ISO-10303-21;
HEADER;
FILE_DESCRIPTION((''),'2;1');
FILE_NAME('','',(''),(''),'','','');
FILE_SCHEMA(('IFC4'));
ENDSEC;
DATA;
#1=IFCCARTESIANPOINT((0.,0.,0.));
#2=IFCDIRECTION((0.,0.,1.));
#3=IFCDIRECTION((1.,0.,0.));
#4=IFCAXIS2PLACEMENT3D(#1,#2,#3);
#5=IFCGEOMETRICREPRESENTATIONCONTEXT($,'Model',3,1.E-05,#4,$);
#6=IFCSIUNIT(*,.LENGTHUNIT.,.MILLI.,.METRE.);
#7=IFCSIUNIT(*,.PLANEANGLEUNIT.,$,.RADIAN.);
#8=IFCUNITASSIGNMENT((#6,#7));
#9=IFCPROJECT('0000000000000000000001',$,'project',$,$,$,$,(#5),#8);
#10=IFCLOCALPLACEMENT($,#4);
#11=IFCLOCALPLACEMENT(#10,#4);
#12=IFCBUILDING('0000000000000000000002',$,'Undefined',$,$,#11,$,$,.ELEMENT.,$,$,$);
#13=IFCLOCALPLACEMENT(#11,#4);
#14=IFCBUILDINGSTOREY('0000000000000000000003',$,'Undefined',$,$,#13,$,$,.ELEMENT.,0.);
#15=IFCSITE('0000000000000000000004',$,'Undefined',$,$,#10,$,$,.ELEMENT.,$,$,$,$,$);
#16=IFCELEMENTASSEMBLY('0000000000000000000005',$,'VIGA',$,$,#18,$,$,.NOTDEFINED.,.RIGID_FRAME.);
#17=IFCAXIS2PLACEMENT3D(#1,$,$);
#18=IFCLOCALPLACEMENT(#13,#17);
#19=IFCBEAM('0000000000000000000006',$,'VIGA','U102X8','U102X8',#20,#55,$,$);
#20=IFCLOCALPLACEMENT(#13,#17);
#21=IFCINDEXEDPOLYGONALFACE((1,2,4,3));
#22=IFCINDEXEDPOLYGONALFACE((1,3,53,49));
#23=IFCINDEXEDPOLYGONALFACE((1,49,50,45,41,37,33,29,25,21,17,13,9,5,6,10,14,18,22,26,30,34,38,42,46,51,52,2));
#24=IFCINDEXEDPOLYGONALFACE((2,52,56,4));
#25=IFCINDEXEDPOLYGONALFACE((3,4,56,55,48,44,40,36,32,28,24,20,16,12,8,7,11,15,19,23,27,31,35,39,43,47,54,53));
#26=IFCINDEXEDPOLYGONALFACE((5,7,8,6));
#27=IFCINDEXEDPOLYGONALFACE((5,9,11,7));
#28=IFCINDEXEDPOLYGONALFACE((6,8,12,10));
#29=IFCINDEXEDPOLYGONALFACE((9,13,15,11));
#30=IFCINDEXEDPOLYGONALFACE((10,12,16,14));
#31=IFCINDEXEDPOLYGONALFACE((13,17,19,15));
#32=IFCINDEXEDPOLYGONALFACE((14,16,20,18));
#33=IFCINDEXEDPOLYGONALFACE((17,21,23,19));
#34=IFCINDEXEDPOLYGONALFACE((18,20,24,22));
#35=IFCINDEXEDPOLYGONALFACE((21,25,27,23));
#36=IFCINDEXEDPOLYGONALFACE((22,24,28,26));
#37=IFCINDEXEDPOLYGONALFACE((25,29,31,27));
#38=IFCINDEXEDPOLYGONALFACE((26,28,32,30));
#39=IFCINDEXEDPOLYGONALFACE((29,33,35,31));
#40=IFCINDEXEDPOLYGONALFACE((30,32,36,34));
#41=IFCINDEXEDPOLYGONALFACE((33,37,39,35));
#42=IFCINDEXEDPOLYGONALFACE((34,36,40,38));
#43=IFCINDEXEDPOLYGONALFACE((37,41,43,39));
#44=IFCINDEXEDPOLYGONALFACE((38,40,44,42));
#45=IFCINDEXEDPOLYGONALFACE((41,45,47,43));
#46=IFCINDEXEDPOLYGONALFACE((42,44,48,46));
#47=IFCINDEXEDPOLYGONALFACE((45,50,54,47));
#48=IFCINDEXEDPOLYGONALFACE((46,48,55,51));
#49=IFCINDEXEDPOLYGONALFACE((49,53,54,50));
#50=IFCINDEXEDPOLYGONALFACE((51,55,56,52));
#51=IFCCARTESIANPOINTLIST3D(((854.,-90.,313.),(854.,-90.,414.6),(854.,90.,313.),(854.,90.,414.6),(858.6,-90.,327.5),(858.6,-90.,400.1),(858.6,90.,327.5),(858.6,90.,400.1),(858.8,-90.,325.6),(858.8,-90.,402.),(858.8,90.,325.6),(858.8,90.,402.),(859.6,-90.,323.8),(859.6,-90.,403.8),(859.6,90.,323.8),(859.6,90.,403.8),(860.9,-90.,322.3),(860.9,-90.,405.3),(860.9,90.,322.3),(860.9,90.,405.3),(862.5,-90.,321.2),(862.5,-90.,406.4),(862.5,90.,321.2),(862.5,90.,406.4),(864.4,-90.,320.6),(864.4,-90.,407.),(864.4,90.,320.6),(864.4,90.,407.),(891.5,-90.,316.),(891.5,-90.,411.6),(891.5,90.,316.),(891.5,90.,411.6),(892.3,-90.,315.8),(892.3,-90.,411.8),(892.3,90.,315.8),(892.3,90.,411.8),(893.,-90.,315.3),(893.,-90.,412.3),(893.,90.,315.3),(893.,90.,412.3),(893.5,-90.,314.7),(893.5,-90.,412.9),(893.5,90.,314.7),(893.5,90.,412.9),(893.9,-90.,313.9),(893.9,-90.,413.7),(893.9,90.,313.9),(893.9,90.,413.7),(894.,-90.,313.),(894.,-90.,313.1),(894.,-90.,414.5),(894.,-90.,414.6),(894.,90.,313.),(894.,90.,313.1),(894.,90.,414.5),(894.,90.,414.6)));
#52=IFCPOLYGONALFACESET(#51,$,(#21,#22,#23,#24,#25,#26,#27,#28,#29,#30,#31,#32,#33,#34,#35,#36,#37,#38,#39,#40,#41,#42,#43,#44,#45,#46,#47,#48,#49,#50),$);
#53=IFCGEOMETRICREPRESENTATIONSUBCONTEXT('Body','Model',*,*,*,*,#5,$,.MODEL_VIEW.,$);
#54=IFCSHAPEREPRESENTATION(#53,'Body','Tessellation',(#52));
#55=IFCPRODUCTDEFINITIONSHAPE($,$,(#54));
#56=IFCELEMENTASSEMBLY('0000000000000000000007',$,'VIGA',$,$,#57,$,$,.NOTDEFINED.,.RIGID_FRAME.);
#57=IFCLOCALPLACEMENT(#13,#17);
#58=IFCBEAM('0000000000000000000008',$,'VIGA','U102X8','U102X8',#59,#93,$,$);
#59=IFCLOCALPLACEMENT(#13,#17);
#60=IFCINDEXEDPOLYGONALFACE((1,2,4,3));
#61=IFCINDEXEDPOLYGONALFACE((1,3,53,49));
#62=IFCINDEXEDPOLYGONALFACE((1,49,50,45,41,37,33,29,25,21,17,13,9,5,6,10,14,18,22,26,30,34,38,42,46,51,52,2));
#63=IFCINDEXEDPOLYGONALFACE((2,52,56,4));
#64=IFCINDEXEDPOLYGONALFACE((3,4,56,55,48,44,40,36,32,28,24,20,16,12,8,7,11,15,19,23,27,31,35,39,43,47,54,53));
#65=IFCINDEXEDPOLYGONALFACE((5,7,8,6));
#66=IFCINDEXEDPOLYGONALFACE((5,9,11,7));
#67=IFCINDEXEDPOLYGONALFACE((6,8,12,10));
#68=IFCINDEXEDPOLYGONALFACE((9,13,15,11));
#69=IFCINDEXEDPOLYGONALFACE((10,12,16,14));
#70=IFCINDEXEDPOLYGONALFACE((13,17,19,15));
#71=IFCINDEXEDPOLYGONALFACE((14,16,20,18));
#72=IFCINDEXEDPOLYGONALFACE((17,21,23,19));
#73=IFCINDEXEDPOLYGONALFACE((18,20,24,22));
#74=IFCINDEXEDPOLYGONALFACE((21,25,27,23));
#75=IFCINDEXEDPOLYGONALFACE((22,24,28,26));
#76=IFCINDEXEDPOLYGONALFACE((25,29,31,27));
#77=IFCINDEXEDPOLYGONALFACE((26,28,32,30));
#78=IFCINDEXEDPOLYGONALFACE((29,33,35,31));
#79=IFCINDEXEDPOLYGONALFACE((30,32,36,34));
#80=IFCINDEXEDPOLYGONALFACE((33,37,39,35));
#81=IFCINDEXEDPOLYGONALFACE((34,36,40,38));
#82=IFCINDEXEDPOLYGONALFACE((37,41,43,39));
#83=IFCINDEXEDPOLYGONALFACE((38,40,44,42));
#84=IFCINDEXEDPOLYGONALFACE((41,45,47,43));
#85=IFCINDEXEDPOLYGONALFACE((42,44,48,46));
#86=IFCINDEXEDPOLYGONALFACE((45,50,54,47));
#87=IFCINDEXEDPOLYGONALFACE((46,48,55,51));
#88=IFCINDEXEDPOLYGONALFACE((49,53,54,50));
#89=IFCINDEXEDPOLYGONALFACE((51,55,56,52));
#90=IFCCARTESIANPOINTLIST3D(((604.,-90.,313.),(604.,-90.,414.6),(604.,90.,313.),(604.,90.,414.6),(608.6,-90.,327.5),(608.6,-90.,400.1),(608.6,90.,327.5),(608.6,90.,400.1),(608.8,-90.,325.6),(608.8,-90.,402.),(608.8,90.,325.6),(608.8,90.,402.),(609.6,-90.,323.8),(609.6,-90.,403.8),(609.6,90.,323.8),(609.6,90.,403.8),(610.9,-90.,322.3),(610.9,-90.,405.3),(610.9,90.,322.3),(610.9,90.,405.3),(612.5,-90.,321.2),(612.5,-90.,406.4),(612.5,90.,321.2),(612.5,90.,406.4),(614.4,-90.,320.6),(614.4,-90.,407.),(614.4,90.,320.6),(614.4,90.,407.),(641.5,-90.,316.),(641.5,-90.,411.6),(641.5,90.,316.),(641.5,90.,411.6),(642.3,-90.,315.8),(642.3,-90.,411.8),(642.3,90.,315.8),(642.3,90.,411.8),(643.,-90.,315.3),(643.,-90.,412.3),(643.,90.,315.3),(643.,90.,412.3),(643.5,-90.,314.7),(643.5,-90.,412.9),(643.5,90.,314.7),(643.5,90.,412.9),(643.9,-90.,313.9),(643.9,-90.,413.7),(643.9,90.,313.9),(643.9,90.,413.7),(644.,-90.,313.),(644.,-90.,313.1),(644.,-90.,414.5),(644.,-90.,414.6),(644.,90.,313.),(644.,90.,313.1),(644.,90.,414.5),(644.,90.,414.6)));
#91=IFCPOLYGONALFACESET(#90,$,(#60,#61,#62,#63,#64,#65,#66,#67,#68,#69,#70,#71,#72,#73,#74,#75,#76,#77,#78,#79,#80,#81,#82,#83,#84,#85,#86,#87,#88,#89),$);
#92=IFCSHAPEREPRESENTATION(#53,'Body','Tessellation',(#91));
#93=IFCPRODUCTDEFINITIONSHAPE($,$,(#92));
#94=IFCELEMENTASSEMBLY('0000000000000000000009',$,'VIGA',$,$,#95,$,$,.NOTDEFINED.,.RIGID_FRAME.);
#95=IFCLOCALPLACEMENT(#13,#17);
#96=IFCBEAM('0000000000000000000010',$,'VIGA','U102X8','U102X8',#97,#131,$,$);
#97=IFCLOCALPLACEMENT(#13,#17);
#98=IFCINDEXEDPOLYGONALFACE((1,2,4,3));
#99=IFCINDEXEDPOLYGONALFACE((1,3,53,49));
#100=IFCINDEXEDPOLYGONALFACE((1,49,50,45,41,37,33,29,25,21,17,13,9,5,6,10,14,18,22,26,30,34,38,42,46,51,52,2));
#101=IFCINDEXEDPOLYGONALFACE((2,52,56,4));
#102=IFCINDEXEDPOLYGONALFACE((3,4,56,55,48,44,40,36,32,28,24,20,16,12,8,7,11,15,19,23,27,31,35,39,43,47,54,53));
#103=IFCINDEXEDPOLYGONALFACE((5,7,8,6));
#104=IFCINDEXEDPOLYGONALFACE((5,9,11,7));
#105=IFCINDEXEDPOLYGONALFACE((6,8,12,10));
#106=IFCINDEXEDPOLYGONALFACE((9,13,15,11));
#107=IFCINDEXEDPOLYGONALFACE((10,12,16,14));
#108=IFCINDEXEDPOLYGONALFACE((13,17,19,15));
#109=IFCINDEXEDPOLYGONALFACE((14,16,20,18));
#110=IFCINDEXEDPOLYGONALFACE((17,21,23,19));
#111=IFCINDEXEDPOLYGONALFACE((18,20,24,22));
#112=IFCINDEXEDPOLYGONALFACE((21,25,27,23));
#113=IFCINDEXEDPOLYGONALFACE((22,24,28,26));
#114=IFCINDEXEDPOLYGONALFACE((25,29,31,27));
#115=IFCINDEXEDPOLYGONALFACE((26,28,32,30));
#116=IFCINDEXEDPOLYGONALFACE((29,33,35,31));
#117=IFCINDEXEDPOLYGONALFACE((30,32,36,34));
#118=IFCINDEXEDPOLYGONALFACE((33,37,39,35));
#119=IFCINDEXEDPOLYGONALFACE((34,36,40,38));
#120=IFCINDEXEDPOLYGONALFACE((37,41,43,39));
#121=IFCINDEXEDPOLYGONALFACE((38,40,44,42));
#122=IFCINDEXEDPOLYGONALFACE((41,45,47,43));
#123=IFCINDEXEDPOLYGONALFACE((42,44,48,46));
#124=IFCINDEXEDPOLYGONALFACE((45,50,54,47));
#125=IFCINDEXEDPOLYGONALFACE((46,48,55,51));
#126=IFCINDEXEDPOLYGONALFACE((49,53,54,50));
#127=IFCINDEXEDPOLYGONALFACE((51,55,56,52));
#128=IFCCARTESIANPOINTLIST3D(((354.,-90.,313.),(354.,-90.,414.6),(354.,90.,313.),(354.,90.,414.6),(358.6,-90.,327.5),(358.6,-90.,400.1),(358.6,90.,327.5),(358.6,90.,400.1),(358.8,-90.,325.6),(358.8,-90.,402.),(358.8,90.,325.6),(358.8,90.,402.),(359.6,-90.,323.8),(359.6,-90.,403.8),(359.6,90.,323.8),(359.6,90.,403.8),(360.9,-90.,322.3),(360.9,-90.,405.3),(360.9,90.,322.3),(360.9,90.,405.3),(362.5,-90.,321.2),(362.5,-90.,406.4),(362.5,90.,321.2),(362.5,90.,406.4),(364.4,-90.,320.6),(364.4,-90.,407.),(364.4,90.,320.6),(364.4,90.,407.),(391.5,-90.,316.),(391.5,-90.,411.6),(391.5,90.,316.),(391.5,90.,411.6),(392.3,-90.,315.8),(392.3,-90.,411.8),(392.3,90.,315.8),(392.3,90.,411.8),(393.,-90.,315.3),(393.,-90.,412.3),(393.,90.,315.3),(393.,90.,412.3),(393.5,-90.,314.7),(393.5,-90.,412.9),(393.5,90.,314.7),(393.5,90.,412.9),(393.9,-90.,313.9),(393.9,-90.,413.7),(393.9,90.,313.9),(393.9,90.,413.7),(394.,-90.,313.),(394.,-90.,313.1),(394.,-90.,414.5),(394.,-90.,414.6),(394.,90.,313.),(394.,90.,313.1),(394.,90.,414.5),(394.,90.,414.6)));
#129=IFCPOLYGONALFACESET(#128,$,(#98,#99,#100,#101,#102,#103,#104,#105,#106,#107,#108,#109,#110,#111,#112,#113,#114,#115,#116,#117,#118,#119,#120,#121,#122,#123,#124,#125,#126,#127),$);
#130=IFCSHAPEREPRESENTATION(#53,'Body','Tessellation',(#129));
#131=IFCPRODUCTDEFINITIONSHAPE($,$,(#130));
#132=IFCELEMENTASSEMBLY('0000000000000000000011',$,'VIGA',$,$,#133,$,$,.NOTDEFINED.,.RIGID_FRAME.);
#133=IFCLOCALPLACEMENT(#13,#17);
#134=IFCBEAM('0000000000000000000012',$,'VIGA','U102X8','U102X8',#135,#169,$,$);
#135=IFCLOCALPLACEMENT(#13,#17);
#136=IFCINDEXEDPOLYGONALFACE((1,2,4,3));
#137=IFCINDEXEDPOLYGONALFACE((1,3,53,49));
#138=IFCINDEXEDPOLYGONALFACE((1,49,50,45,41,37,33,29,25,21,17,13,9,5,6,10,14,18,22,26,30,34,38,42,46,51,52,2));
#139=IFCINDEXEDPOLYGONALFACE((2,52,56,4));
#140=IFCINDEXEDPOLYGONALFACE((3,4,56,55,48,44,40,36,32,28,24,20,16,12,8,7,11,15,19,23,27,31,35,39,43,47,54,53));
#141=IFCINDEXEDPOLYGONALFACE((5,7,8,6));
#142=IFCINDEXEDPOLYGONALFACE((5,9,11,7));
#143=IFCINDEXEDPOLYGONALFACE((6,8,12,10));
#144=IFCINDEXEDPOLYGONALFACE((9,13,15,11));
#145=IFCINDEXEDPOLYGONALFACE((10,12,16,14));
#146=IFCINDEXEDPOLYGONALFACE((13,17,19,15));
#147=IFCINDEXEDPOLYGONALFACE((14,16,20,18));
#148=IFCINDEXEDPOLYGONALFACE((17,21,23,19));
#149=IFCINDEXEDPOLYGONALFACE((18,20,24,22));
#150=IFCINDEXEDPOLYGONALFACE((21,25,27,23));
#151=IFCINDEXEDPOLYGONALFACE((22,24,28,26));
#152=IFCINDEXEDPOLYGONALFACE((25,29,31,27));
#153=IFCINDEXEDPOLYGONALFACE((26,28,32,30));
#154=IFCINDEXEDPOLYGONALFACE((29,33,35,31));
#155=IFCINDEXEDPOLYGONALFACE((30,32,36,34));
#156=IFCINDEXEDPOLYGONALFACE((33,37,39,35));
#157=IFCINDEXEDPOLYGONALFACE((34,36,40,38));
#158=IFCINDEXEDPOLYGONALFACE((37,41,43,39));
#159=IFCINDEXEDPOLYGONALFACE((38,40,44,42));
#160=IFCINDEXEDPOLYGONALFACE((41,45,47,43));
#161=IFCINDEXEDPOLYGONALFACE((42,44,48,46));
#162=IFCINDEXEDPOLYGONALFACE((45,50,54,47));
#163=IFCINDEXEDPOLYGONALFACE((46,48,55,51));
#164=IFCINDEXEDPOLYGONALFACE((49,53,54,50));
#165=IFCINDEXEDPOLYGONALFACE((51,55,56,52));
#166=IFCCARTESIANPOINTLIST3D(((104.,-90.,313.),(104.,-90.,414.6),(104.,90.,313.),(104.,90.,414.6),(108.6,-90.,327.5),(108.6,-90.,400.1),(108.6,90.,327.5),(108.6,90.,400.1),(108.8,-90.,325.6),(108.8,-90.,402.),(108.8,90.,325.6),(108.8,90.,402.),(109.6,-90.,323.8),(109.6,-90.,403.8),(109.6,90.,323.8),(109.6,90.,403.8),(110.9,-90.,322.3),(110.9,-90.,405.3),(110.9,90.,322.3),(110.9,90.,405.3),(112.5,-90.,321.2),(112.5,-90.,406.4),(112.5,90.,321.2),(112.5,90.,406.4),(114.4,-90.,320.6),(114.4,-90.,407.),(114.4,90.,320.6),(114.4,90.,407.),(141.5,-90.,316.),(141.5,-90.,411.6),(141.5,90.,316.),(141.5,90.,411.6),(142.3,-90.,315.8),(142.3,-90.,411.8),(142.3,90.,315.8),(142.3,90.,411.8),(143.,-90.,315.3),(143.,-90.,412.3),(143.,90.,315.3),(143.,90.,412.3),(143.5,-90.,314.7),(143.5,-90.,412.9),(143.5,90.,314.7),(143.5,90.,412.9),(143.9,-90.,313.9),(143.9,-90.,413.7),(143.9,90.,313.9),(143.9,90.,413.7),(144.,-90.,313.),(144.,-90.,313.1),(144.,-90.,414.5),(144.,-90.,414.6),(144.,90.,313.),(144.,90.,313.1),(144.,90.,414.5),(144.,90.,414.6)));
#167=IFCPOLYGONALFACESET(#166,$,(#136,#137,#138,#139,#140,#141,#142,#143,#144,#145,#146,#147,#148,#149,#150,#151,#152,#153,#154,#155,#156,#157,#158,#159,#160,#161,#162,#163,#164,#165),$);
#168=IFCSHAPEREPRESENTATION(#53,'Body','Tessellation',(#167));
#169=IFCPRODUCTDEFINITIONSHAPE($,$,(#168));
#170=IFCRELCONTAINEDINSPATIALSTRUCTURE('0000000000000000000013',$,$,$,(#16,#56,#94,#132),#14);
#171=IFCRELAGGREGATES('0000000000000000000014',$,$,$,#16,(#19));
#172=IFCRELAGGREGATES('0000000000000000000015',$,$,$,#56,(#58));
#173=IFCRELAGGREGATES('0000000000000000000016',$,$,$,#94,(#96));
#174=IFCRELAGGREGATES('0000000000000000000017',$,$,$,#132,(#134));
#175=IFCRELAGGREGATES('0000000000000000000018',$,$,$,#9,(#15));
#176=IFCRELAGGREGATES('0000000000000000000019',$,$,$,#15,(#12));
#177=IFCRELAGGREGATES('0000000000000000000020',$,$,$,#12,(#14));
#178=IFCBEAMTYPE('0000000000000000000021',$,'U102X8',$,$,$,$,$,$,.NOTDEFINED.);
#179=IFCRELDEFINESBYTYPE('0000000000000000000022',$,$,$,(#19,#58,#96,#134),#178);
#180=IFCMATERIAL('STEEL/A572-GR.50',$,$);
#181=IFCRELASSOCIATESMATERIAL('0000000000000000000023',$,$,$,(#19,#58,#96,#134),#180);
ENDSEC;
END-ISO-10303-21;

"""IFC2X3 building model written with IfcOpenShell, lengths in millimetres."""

from ifc_helpers import new_model, si_unit, frame, origin_with_axes, origin_2d_with_axis, place, context, subcontext, project, spatial, u_section, extrude, material, type_object, element, aggregate, save


model = new_model("IFC2X3")

# Units and contexts
model_context = context("Model", 3, precision=1e-05, world=origin_with_axes())
body_context = subcontext(model_context, "Body", "Model", "MODEL_VIEW")
ifc_project = project(units=[si_unit("LENGTHUNIT", "METRE", prefix="MILLI"), si_unit("PLANEANGLEUNIT", "RADIAN")], contexts=[model_context])

# Site, building, storey
site_placement = place(None, origin_with_axes())
site = spatial("IfcSite", under=ifc_project, at=site_placement, Name="Undefined", CompositionType="ELEMENT")
building_placement = place(site_placement, origin_with_axes())
building = spatial("IfcBuilding", under=site, at=building_placement, Name="Undefined", CompositionType="ELEMENT")
storey_placement = place(building_placement, origin_with_axes())
storey = spatial("IfcBuildingStorey", under=building, at=storey_placement, Name="Undefined", CompositionType="ELEMENT", Elevation=0.0)

# Element assemblies, beams
ifc_material_1 = material(Name="STEEL/A572-GR.50")
beam_type_1 = type_object("IfcBeamType", Name="U102X8", PredefinedType="NOTDEFINED")
assembly_1_placement = place(storey_placement, origin_with_axes())
assembly_1 = element("IfcElementAssembly", 1, at=assembly_1_placement, inside=storey, Name="VIGA", AssemblyPlace="NOTDEFINED", PredefinedType="RIGID_FRAME")
beam_1_placement = place(assembly_1_placement, frame((874.0, -90.0, 363.8), z_axis=(0.0, 0.0, 1.0), x_axis=(0.0, 1.0, 0.0)))
beam_1 = element("IfcBeam", 2, at=beam_1_placement, type_object=beam_type_1, material=ifc_material_1, Name="VIGA", Description="U102X8", ObjectType="U102X8", context=body_context, shape_type="SweptSolid", body=[
    extrude(u_section(Depth=101.6, FlangeWidth=40.0, WebThickness=4.6, FlangeThickness=6.0, FilletRadius=7.0, EdgeRadius=3.0, FlangeSlope=0.16839, at=origin_2d_with_axis()), frame((180.0, 0.0, 0.0), z_axis=(-1.0, 0.0, 0.0), x_axis=(0.0, -1.0, 0.0)), (0.0, 0.0, 1.0), 180.0),
])
aggregate(assembly_1, [beam_1])
assembly_2_placement = place(storey_placement, origin_with_axes())
assembly_2 = element("IfcElementAssembly", 3, at=assembly_2_placement, inside=storey, Name="VIGA", AssemblyPlace="NOTDEFINED", PredefinedType="RIGID_FRAME")
beam_2_placement = place(assembly_2_placement, frame((624.0, -90.0, 363.8), z_axis=(0.0, 0.0, 1.0), x_axis=(0.0, 1.0, 0.0)))
beam_2 = element("IfcBeam", 4, at=beam_2_placement, type_object=beam_type_1, material=ifc_material_1, Name="VIGA", Description="U102X8", ObjectType="U102X8", context=body_context, shape_type="SweptSolid", body=[
    extrude(u_section(Depth=101.6, FlangeWidth=40.0, WebThickness=4.6, FlangeThickness=6.0, FilletRadius=7.0, EdgeRadius=3.0, FlangeSlope=0.16839, at=origin_2d_with_axis()), frame((180.0, 0.0, 0.0), z_axis=(-1.0, 0.0, 0.0), x_axis=(0.0, -1.0, 0.0)), (0.0, 0.0, 1.0), 180.0),
])
aggregate(assembly_2, [beam_2])
assembly_3_placement = place(storey_placement, origin_with_axes())
assembly_3 = element("IfcElementAssembly", 5, at=assembly_3_placement, inside=storey, Name="VIGA", AssemblyPlace="NOTDEFINED", PredefinedType="RIGID_FRAME")
beam_3_placement = place(assembly_3_placement, frame((374.0, -90.0, 363.8), z_axis=(0.0, 0.0, 1.0), x_axis=(0.0, 1.0, 0.0)))
beam_3 = element("IfcBeam", 6, at=beam_3_placement, type_object=beam_type_1, material=ifc_material_1, Name="VIGA", Description="U102X8", ObjectType="U102X8", context=body_context, shape_type="SweptSolid", body=[
    extrude(u_section(Depth=101.6, FlangeWidth=40.0, WebThickness=4.6, FlangeThickness=6.0, FilletRadius=7.0, EdgeRadius=3.0, FlangeSlope=0.16839, at=origin_2d_with_axis()), frame((180.0, 0.0, 0.0), z_axis=(-1.0, 0.0, 0.0), x_axis=(0.0, -1.0, 0.0)), (0.0, 0.0, 1.0), 180.0),
])
aggregate(assembly_3, [beam_3])
assembly_4_placement = place(storey_placement, origin_with_axes())
assembly_4 = element("IfcElementAssembly", 7, at=assembly_4_placement, inside=storey, Name="VIGA", AssemblyPlace="NOTDEFINED", PredefinedType="RIGID_FRAME")
beam_4_placement = place(assembly_4_placement, frame((124.0, -90.0, 363.8), z_axis=(0.0, 0.0, 1.0), x_axis=(0.0, 1.0, 0.0)))
beam_4 = element("IfcBeam", 8, at=beam_4_placement, type_object=beam_type_1, material=ifc_material_1, Name="VIGA", Description="U102X8", ObjectType="U102X8", context=body_context, shape_type="SweptSolid", body=[
    extrude(u_section(Depth=101.6, FlangeWidth=40.0, WebThickness=4.6, FlangeThickness=6.0, FilletRadius=7.0, EdgeRadius=3.0, FlangeSlope=0.16839, at=origin_2d_with_axis()), frame((180.0, 0.0, 0.0), z_axis=(-1.0, 0.0, 0.0), x_axis=(0.0, -1.0, 0.0)), (0.0, 0.0, 1.0), 180.0),
])
aggregate(assembly_4, [beam_4])

save(model, "model.ifc")
